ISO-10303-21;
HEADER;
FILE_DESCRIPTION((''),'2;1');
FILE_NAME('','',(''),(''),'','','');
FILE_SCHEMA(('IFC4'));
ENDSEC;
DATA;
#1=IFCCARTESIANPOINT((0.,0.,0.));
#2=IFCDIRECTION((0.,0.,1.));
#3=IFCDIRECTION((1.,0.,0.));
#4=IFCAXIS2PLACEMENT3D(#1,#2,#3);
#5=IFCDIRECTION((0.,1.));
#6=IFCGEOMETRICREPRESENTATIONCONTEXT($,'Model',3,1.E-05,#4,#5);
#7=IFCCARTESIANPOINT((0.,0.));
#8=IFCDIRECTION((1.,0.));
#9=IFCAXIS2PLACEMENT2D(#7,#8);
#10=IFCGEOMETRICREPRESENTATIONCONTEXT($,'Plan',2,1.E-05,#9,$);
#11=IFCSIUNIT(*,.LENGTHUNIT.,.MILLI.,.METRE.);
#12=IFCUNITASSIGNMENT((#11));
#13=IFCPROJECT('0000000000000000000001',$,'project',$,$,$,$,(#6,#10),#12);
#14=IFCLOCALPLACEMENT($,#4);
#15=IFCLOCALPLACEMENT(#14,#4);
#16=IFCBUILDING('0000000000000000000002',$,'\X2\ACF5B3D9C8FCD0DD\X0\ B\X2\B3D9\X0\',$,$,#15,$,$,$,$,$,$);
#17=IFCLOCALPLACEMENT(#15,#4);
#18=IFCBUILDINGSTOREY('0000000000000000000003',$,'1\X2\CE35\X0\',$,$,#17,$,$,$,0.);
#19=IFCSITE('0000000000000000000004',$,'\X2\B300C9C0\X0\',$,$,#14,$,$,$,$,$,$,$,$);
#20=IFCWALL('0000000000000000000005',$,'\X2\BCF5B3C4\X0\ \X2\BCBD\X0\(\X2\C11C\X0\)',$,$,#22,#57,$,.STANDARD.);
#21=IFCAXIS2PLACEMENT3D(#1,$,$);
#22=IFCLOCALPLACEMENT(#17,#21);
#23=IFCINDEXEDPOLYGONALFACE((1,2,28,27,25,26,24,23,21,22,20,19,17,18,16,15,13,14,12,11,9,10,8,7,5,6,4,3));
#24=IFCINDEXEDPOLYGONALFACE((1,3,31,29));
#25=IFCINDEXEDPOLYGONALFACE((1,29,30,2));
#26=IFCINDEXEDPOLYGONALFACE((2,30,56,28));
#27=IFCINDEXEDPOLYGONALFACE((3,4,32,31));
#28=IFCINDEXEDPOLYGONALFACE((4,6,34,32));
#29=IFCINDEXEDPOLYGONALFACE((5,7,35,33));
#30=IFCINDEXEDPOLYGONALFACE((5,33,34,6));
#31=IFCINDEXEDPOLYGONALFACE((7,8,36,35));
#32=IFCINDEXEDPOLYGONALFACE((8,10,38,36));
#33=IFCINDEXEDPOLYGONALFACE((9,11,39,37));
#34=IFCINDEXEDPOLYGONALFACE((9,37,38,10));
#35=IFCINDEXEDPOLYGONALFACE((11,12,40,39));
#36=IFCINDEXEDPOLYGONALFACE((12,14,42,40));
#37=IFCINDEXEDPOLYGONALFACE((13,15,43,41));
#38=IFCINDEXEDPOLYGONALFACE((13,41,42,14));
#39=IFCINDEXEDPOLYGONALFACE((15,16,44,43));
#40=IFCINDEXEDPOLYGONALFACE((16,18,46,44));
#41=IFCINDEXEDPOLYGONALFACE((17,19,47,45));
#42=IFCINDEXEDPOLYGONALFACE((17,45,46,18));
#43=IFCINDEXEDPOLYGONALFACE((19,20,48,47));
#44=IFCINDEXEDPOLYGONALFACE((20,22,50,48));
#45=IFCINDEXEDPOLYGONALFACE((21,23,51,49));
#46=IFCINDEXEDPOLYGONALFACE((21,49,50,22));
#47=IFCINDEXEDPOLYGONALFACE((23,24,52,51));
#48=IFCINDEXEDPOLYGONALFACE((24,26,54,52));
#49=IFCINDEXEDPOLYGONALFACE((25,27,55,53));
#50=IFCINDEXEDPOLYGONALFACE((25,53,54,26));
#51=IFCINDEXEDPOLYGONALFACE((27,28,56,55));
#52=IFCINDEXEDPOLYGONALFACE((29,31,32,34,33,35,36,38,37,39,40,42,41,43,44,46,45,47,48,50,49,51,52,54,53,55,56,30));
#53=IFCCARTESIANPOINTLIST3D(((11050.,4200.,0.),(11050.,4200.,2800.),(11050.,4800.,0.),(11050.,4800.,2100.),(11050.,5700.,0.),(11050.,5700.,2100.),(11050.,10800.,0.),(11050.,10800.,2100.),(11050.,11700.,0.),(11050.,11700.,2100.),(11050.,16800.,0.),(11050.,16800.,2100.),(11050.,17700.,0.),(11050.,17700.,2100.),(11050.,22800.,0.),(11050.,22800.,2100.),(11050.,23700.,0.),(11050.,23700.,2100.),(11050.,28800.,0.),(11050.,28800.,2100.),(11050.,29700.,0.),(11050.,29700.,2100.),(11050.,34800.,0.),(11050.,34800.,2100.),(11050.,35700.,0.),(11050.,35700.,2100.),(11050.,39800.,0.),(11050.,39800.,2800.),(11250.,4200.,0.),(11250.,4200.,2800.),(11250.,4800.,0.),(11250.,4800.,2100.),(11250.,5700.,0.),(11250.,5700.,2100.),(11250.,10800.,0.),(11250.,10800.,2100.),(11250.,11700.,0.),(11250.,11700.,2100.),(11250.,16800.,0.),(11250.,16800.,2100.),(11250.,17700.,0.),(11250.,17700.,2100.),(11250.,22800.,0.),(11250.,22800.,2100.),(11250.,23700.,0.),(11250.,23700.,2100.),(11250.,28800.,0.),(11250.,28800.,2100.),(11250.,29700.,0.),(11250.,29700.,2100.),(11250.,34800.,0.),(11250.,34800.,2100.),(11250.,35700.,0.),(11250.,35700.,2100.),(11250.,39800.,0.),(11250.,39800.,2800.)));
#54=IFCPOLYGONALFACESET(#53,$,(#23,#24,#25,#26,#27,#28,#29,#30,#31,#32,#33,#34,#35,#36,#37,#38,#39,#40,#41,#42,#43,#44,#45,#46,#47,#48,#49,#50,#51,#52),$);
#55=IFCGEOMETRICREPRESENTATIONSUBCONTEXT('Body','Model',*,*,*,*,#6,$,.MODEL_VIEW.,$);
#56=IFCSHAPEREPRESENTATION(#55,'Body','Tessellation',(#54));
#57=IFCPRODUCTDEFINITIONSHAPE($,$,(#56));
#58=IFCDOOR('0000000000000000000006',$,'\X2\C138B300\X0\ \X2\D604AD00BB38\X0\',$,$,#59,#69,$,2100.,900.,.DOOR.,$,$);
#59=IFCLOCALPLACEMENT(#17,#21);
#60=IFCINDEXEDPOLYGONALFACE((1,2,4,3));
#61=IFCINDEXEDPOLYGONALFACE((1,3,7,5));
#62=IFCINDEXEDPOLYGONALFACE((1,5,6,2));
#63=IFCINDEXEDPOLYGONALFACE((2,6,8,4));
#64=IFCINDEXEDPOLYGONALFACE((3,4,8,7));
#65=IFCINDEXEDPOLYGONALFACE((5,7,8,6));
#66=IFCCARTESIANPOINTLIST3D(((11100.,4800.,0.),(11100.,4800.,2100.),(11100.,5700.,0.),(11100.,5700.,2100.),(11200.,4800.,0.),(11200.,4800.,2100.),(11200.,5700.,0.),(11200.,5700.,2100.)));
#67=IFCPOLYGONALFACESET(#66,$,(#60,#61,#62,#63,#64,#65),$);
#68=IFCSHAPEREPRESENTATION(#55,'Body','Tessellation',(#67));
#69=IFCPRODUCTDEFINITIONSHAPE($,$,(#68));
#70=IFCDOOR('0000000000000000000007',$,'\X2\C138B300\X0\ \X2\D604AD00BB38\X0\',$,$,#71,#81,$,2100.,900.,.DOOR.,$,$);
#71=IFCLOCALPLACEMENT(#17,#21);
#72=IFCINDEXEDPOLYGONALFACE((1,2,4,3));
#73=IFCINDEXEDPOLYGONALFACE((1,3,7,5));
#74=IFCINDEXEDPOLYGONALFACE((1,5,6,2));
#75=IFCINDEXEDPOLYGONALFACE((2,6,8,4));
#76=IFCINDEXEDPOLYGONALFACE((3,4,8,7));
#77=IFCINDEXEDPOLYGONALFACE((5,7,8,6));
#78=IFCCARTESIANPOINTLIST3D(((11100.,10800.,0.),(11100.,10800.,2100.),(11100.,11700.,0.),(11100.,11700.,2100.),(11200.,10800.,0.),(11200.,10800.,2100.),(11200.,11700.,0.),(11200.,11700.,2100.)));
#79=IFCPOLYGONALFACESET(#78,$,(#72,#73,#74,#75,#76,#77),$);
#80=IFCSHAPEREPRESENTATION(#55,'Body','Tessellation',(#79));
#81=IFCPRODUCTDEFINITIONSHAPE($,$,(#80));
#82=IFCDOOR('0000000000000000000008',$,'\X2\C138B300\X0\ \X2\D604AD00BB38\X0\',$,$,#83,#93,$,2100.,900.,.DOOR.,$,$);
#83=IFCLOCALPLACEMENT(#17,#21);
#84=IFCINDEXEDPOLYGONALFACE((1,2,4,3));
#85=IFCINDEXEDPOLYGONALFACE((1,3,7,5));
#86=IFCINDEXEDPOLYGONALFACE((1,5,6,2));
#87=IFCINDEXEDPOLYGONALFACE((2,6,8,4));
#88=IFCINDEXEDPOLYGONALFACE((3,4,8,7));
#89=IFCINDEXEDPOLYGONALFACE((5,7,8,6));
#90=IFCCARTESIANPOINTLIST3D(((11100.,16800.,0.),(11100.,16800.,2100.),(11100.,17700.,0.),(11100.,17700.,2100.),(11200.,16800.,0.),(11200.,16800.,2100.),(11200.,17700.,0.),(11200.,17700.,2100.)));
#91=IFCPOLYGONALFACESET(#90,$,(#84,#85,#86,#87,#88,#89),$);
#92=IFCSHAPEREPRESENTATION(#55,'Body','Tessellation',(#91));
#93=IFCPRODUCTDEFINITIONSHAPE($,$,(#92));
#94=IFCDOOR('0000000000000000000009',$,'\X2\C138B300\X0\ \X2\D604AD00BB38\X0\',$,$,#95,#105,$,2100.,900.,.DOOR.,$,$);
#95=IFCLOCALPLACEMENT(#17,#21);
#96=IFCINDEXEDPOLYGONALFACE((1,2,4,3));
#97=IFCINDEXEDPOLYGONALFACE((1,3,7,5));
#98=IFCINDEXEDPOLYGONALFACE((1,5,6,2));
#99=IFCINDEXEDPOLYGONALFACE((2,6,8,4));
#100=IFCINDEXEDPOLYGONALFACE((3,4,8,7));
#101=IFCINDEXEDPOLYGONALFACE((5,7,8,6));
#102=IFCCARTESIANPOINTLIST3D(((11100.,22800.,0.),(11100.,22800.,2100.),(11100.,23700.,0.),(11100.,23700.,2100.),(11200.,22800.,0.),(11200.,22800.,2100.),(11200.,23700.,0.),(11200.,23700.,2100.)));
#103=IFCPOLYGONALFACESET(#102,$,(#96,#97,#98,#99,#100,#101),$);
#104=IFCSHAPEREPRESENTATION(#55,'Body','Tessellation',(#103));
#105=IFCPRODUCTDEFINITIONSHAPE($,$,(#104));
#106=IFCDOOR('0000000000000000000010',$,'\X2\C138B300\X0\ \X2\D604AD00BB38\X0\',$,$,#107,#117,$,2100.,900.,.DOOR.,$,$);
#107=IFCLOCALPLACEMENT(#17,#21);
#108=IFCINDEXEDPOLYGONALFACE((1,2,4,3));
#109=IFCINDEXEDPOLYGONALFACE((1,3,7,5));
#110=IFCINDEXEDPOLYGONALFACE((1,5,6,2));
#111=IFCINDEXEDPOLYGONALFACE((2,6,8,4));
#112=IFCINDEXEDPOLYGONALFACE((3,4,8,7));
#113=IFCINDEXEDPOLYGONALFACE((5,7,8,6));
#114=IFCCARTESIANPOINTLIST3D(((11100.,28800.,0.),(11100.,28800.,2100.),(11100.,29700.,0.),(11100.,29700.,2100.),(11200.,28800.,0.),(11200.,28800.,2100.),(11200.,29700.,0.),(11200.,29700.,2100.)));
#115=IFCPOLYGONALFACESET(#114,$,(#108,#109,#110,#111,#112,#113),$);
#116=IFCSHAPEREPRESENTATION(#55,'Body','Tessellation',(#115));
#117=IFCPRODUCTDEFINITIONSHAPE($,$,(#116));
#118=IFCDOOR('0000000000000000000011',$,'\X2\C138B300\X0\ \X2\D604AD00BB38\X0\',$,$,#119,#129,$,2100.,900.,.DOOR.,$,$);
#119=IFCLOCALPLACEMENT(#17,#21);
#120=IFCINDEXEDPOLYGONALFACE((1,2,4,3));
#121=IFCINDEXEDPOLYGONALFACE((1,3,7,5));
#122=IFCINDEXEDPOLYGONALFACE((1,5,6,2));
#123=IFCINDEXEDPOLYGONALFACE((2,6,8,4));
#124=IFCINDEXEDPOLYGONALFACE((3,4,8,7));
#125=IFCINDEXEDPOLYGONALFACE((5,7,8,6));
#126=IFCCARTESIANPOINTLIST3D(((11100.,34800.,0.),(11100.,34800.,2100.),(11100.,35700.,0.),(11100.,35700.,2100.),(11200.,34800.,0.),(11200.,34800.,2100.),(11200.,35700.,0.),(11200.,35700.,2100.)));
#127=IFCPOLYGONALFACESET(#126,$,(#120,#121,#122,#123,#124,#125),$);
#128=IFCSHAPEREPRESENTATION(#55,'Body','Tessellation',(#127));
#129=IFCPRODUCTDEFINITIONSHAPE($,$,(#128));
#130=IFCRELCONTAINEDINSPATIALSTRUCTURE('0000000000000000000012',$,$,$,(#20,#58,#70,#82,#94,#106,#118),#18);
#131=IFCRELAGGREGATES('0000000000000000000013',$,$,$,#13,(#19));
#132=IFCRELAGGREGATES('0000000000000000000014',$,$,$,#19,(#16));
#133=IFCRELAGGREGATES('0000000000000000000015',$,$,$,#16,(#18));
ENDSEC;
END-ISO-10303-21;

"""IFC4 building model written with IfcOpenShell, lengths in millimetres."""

from ifc_helpers import new_model, si_unit, direction, origin_with_axes, origin_2d_with_axis, place, context, subcontext, project, spatial, polyline, outline, extrude, element, fill, save


model = new_model("IFC4")

# Units and contexts
model_context = context("Model", 3, precision=1e-05, world=origin_with_axes(), true_north=direction((0.0, 1.0)))
plan_context = context("Plan", 2, precision=1e-05, world=origin_2d_with_axis())
body_context = subcontext(model_context, "Body", "Model", "MODEL_VIEW")
ifc_project = project(units=[si_unit("LENGTHUNIT", "METRE", prefix="MILLI")], contexts=[model_context, plan_context])

# Site, building, storey
site_placement = place(None, origin_with_axes())
site = spatial("IfcSite", under=ifc_project, at=site_placement, Name="대지")
building_placement = place(site_placement, origin_with_axes())
building = spatial("IfcBuilding", under=site, at=building_placement, Name="공동주택 B동")
storey_placement = place(building_placement, origin_with_axes())
storey = spatial("IfcBuildingStorey", under=building, at=storey_placement, Name="1층", Elevation=0.0)

# Wall, openings, doors
wall_1_placement = place(storey_placement, origin_with_axes())
wall_1 = element("IfcWall", 1, at=wall_1_placement, inside=storey, Name="복도 벽(서)", PredefinedType="STANDARD", context=body_context, shape_type="SweptSolid", body=[
    extrude(outline(polyline([(11050.0, 4200.0), (11050.0, 39800.0), (11250.0, 39800.0), (11250.0, 4200.0), (11050.0, 4200.0)])), origin_with_axes(), (0.0, 0.0, 1.0), 2800.0),
])
opening_1_placement = place(storey_placement, origin_with_axes())
opening_1 = element("IfcOpeningElement", 2, at=opening_1_placement, cuts=wall_1, PredefinedType="OPENING", context=body_context, shape_type="SweptSolid", body=[
    extrude(outline(polyline([(11300.0, 4800.0), (11300.0, 5700.0), (11000.0, 5700.0), (11000.0, 4800.0), (11300.0, 4800.0)])), origin_with_axes(), (0.0, 0.0, 1.0), 2100.0),
])
opening_2_placement = place(storey_placement, origin_with_axes())
opening_2 = element("IfcOpeningElement", 3, at=opening_2_placement, cuts=wall_1, PredefinedType="OPENING", context=body_context, shape_type="SweptSolid", body=[
    extrude(outline(polyline([(11300.0, 10800.0), (11300.0, 11700.0), (11000.0, 11700.0), (11000.0, 10800.0), (11300.0, 10800.0)])), origin_with_axes(), (0.0, 0.0, 1.0), 2100.0),
])
opening_3_placement = place(storey_placement, origin_with_axes())
opening_3 = element("IfcOpeningElement", 4, at=opening_3_placement, cuts=wall_1, PredefinedType="OPENING", context=body_context, shape_type="SweptSolid", body=[
    extrude(outline(polyline([(11300.0, 16800.0), (11300.0, 17700.0), (11000.0, 17700.0), (11000.0, 16800.0), (11300.0, 16800.0)])), origin_with_axes(), (0.0, 0.0, 1.0), 2100.0),
])
opening_4_placement = place(storey_placement, origin_with_axes())
opening_4 = element("IfcOpeningElement", 5, at=opening_4_placement, cuts=wall_1, PredefinedType="OPENING", context=body_context, shape_type="SweptSolid", body=[
    extrude(outline(polyline([(11300.0, 22800.0), (11300.0, 23700.0), (11000.0, 23700.0), (11000.0, 22800.0), (11300.0, 22800.0)])), origin_with_axes(), (0.0, 0.0, 1.0), 2100.0),
])
opening_5_placement = place(storey_placement, origin_with_axes())
opening_5 = element("IfcOpeningElement", 6, at=opening_5_placement, cuts=wall_1, PredefinedType="OPENING", context=body_context, shape_type="SweptSolid", body=[
    extrude(outline(polyline([(11300.0, 28800.0), (11300.0, 29700.0), (11000.0, 29700.0), (11000.0, 28800.0), (11300.0, 28800.0)])), origin_with_axes(), (0.0, 0.0, 1.0), 2100.0),
])
opening_6_placement = place(storey_placement, origin_with_axes())
opening_6 = element("IfcOpeningElement", 7, at=opening_6_placement, cuts=wall_1, PredefinedType="OPENING", context=body_context, shape_type="SweptSolid", body=[
    extrude(outline(polyline([(11300.0, 34800.0), (11300.0, 35700.0), (11000.0, 35700.0), (11000.0, 34800.0), (11300.0, 34800.0)])), origin_with_axes(), (0.0, 0.0, 1.0), 2100.0),
])
door_1_placement = place(storey_placement, origin_with_axes())
door_1 = element("IfcDoor", 8, at=door_1_placement, inside=storey, Name="세대 현관문", OverallHeight=2100.0, OverallWidth=900.0, PredefinedType="DOOR", context=body_context, shape_type="SweptSolid", body=[
    extrude(outline(polyline([(11200.0, 4800.0), (11200.0, 5700.0), (11100.0, 5700.0), (11100.0, 4800.0), (11200.0, 4800.0)])), origin_with_axes(), (0.0, 0.0, 1.0), 2100.0),
])
fill(opening_1, door_1)
door_2_placement = place(storey_placement, origin_with_axes())
door_2 = element("IfcDoor", 9, at=door_2_placement, inside=storey, Name="세대 현관문", OverallHeight=2100.0, OverallWidth=900.0, PredefinedType="DOOR", context=body_context, shape_type="SweptSolid", body=[
    extrude(outline(polyline([(11200.0, 10800.0), (11200.0, 11700.0), (11100.0, 11700.0), (11100.0, 10800.0), (11200.0, 10800.0)])), origin_with_axes(), (0.0, 0.0, 1.0), 2100.0),
])
fill(opening_2, door_2)
door_3_placement = place(storey_placement, origin_with_axes())
door_3 = element("IfcDoor", 10, at=door_3_placement, inside=storey, Name="세대 현관문", OverallHeight=2100.0, OverallWidth=900.0, PredefinedType="DOOR", context=body_context, shape_type="SweptSolid", body=[
    extrude(outline(polyline([(11200.0, 16800.0), (11200.0, 17700.0), (11100.0, 17700.0), (11100.0, 16800.0), (11200.0, 16800.0)])), origin_with_axes(), (0.0, 0.0, 1.0), 2100.0),
])
fill(opening_3, door_3)
door_4_placement = place(storey_placement, origin_with_axes())
door_4 = element("IfcDoor", 11, at=door_4_placement, inside=storey, Name="세대 현관문", OverallHeight=2100.0, OverallWidth=900.0, PredefinedType="DOOR", context=body_context, shape_type="SweptSolid", body=[
    extrude(outline(polyline([(11200.0, 22800.0), (11200.0, 23700.0), (11100.0, 23700.0), (11100.0, 22800.0), (11200.0, 22800.0)])), origin_with_axes(), (0.0, 0.0, 1.0), 2100.0),
])
fill(opening_4, door_4)
door_5_placement = place(storey_placement, origin_with_axes())
door_5 = element("IfcDoor", 12, at=door_5_placement, inside=storey, Name="세대 현관문", OverallHeight=2100.0, OverallWidth=900.0, PredefinedType="DOOR", context=body_context, shape_type="SweptSolid", body=[
    extrude(outline(polyline([(11200.0, 28800.0), (11200.0, 29700.0), (11100.0, 29700.0), (11100.0, 28800.0), (11200.0, 28800.0)])), origin_with_axes(), (0.0, 0.0, 1.0), 2100.0),
])
fill(opening_5, door_5)
door_6_placement = place(storey_placement, origin_with_axes())
door_6 = element("IfcDoor", 13, at=door_6_placement, inside=storey, Name="세대 현관문", OverallHeight=2100.0, OverallWidth=900.0, PredefinedType="DOOR", context=body_context, shape_type="SweptSolid", body=[
    extrude(outline(polyline([(11200.0, 34800.0), (11200.0, 35700.0), (11100.0, 35700.0), (11100.0, 34800.0), (11200.0, 34800.0)])), origin_with_axes(), (0.0, 0.0, 1.0), 2100.0),
])
fill(opening_6, door_6)

save(model, "model.ifc")
